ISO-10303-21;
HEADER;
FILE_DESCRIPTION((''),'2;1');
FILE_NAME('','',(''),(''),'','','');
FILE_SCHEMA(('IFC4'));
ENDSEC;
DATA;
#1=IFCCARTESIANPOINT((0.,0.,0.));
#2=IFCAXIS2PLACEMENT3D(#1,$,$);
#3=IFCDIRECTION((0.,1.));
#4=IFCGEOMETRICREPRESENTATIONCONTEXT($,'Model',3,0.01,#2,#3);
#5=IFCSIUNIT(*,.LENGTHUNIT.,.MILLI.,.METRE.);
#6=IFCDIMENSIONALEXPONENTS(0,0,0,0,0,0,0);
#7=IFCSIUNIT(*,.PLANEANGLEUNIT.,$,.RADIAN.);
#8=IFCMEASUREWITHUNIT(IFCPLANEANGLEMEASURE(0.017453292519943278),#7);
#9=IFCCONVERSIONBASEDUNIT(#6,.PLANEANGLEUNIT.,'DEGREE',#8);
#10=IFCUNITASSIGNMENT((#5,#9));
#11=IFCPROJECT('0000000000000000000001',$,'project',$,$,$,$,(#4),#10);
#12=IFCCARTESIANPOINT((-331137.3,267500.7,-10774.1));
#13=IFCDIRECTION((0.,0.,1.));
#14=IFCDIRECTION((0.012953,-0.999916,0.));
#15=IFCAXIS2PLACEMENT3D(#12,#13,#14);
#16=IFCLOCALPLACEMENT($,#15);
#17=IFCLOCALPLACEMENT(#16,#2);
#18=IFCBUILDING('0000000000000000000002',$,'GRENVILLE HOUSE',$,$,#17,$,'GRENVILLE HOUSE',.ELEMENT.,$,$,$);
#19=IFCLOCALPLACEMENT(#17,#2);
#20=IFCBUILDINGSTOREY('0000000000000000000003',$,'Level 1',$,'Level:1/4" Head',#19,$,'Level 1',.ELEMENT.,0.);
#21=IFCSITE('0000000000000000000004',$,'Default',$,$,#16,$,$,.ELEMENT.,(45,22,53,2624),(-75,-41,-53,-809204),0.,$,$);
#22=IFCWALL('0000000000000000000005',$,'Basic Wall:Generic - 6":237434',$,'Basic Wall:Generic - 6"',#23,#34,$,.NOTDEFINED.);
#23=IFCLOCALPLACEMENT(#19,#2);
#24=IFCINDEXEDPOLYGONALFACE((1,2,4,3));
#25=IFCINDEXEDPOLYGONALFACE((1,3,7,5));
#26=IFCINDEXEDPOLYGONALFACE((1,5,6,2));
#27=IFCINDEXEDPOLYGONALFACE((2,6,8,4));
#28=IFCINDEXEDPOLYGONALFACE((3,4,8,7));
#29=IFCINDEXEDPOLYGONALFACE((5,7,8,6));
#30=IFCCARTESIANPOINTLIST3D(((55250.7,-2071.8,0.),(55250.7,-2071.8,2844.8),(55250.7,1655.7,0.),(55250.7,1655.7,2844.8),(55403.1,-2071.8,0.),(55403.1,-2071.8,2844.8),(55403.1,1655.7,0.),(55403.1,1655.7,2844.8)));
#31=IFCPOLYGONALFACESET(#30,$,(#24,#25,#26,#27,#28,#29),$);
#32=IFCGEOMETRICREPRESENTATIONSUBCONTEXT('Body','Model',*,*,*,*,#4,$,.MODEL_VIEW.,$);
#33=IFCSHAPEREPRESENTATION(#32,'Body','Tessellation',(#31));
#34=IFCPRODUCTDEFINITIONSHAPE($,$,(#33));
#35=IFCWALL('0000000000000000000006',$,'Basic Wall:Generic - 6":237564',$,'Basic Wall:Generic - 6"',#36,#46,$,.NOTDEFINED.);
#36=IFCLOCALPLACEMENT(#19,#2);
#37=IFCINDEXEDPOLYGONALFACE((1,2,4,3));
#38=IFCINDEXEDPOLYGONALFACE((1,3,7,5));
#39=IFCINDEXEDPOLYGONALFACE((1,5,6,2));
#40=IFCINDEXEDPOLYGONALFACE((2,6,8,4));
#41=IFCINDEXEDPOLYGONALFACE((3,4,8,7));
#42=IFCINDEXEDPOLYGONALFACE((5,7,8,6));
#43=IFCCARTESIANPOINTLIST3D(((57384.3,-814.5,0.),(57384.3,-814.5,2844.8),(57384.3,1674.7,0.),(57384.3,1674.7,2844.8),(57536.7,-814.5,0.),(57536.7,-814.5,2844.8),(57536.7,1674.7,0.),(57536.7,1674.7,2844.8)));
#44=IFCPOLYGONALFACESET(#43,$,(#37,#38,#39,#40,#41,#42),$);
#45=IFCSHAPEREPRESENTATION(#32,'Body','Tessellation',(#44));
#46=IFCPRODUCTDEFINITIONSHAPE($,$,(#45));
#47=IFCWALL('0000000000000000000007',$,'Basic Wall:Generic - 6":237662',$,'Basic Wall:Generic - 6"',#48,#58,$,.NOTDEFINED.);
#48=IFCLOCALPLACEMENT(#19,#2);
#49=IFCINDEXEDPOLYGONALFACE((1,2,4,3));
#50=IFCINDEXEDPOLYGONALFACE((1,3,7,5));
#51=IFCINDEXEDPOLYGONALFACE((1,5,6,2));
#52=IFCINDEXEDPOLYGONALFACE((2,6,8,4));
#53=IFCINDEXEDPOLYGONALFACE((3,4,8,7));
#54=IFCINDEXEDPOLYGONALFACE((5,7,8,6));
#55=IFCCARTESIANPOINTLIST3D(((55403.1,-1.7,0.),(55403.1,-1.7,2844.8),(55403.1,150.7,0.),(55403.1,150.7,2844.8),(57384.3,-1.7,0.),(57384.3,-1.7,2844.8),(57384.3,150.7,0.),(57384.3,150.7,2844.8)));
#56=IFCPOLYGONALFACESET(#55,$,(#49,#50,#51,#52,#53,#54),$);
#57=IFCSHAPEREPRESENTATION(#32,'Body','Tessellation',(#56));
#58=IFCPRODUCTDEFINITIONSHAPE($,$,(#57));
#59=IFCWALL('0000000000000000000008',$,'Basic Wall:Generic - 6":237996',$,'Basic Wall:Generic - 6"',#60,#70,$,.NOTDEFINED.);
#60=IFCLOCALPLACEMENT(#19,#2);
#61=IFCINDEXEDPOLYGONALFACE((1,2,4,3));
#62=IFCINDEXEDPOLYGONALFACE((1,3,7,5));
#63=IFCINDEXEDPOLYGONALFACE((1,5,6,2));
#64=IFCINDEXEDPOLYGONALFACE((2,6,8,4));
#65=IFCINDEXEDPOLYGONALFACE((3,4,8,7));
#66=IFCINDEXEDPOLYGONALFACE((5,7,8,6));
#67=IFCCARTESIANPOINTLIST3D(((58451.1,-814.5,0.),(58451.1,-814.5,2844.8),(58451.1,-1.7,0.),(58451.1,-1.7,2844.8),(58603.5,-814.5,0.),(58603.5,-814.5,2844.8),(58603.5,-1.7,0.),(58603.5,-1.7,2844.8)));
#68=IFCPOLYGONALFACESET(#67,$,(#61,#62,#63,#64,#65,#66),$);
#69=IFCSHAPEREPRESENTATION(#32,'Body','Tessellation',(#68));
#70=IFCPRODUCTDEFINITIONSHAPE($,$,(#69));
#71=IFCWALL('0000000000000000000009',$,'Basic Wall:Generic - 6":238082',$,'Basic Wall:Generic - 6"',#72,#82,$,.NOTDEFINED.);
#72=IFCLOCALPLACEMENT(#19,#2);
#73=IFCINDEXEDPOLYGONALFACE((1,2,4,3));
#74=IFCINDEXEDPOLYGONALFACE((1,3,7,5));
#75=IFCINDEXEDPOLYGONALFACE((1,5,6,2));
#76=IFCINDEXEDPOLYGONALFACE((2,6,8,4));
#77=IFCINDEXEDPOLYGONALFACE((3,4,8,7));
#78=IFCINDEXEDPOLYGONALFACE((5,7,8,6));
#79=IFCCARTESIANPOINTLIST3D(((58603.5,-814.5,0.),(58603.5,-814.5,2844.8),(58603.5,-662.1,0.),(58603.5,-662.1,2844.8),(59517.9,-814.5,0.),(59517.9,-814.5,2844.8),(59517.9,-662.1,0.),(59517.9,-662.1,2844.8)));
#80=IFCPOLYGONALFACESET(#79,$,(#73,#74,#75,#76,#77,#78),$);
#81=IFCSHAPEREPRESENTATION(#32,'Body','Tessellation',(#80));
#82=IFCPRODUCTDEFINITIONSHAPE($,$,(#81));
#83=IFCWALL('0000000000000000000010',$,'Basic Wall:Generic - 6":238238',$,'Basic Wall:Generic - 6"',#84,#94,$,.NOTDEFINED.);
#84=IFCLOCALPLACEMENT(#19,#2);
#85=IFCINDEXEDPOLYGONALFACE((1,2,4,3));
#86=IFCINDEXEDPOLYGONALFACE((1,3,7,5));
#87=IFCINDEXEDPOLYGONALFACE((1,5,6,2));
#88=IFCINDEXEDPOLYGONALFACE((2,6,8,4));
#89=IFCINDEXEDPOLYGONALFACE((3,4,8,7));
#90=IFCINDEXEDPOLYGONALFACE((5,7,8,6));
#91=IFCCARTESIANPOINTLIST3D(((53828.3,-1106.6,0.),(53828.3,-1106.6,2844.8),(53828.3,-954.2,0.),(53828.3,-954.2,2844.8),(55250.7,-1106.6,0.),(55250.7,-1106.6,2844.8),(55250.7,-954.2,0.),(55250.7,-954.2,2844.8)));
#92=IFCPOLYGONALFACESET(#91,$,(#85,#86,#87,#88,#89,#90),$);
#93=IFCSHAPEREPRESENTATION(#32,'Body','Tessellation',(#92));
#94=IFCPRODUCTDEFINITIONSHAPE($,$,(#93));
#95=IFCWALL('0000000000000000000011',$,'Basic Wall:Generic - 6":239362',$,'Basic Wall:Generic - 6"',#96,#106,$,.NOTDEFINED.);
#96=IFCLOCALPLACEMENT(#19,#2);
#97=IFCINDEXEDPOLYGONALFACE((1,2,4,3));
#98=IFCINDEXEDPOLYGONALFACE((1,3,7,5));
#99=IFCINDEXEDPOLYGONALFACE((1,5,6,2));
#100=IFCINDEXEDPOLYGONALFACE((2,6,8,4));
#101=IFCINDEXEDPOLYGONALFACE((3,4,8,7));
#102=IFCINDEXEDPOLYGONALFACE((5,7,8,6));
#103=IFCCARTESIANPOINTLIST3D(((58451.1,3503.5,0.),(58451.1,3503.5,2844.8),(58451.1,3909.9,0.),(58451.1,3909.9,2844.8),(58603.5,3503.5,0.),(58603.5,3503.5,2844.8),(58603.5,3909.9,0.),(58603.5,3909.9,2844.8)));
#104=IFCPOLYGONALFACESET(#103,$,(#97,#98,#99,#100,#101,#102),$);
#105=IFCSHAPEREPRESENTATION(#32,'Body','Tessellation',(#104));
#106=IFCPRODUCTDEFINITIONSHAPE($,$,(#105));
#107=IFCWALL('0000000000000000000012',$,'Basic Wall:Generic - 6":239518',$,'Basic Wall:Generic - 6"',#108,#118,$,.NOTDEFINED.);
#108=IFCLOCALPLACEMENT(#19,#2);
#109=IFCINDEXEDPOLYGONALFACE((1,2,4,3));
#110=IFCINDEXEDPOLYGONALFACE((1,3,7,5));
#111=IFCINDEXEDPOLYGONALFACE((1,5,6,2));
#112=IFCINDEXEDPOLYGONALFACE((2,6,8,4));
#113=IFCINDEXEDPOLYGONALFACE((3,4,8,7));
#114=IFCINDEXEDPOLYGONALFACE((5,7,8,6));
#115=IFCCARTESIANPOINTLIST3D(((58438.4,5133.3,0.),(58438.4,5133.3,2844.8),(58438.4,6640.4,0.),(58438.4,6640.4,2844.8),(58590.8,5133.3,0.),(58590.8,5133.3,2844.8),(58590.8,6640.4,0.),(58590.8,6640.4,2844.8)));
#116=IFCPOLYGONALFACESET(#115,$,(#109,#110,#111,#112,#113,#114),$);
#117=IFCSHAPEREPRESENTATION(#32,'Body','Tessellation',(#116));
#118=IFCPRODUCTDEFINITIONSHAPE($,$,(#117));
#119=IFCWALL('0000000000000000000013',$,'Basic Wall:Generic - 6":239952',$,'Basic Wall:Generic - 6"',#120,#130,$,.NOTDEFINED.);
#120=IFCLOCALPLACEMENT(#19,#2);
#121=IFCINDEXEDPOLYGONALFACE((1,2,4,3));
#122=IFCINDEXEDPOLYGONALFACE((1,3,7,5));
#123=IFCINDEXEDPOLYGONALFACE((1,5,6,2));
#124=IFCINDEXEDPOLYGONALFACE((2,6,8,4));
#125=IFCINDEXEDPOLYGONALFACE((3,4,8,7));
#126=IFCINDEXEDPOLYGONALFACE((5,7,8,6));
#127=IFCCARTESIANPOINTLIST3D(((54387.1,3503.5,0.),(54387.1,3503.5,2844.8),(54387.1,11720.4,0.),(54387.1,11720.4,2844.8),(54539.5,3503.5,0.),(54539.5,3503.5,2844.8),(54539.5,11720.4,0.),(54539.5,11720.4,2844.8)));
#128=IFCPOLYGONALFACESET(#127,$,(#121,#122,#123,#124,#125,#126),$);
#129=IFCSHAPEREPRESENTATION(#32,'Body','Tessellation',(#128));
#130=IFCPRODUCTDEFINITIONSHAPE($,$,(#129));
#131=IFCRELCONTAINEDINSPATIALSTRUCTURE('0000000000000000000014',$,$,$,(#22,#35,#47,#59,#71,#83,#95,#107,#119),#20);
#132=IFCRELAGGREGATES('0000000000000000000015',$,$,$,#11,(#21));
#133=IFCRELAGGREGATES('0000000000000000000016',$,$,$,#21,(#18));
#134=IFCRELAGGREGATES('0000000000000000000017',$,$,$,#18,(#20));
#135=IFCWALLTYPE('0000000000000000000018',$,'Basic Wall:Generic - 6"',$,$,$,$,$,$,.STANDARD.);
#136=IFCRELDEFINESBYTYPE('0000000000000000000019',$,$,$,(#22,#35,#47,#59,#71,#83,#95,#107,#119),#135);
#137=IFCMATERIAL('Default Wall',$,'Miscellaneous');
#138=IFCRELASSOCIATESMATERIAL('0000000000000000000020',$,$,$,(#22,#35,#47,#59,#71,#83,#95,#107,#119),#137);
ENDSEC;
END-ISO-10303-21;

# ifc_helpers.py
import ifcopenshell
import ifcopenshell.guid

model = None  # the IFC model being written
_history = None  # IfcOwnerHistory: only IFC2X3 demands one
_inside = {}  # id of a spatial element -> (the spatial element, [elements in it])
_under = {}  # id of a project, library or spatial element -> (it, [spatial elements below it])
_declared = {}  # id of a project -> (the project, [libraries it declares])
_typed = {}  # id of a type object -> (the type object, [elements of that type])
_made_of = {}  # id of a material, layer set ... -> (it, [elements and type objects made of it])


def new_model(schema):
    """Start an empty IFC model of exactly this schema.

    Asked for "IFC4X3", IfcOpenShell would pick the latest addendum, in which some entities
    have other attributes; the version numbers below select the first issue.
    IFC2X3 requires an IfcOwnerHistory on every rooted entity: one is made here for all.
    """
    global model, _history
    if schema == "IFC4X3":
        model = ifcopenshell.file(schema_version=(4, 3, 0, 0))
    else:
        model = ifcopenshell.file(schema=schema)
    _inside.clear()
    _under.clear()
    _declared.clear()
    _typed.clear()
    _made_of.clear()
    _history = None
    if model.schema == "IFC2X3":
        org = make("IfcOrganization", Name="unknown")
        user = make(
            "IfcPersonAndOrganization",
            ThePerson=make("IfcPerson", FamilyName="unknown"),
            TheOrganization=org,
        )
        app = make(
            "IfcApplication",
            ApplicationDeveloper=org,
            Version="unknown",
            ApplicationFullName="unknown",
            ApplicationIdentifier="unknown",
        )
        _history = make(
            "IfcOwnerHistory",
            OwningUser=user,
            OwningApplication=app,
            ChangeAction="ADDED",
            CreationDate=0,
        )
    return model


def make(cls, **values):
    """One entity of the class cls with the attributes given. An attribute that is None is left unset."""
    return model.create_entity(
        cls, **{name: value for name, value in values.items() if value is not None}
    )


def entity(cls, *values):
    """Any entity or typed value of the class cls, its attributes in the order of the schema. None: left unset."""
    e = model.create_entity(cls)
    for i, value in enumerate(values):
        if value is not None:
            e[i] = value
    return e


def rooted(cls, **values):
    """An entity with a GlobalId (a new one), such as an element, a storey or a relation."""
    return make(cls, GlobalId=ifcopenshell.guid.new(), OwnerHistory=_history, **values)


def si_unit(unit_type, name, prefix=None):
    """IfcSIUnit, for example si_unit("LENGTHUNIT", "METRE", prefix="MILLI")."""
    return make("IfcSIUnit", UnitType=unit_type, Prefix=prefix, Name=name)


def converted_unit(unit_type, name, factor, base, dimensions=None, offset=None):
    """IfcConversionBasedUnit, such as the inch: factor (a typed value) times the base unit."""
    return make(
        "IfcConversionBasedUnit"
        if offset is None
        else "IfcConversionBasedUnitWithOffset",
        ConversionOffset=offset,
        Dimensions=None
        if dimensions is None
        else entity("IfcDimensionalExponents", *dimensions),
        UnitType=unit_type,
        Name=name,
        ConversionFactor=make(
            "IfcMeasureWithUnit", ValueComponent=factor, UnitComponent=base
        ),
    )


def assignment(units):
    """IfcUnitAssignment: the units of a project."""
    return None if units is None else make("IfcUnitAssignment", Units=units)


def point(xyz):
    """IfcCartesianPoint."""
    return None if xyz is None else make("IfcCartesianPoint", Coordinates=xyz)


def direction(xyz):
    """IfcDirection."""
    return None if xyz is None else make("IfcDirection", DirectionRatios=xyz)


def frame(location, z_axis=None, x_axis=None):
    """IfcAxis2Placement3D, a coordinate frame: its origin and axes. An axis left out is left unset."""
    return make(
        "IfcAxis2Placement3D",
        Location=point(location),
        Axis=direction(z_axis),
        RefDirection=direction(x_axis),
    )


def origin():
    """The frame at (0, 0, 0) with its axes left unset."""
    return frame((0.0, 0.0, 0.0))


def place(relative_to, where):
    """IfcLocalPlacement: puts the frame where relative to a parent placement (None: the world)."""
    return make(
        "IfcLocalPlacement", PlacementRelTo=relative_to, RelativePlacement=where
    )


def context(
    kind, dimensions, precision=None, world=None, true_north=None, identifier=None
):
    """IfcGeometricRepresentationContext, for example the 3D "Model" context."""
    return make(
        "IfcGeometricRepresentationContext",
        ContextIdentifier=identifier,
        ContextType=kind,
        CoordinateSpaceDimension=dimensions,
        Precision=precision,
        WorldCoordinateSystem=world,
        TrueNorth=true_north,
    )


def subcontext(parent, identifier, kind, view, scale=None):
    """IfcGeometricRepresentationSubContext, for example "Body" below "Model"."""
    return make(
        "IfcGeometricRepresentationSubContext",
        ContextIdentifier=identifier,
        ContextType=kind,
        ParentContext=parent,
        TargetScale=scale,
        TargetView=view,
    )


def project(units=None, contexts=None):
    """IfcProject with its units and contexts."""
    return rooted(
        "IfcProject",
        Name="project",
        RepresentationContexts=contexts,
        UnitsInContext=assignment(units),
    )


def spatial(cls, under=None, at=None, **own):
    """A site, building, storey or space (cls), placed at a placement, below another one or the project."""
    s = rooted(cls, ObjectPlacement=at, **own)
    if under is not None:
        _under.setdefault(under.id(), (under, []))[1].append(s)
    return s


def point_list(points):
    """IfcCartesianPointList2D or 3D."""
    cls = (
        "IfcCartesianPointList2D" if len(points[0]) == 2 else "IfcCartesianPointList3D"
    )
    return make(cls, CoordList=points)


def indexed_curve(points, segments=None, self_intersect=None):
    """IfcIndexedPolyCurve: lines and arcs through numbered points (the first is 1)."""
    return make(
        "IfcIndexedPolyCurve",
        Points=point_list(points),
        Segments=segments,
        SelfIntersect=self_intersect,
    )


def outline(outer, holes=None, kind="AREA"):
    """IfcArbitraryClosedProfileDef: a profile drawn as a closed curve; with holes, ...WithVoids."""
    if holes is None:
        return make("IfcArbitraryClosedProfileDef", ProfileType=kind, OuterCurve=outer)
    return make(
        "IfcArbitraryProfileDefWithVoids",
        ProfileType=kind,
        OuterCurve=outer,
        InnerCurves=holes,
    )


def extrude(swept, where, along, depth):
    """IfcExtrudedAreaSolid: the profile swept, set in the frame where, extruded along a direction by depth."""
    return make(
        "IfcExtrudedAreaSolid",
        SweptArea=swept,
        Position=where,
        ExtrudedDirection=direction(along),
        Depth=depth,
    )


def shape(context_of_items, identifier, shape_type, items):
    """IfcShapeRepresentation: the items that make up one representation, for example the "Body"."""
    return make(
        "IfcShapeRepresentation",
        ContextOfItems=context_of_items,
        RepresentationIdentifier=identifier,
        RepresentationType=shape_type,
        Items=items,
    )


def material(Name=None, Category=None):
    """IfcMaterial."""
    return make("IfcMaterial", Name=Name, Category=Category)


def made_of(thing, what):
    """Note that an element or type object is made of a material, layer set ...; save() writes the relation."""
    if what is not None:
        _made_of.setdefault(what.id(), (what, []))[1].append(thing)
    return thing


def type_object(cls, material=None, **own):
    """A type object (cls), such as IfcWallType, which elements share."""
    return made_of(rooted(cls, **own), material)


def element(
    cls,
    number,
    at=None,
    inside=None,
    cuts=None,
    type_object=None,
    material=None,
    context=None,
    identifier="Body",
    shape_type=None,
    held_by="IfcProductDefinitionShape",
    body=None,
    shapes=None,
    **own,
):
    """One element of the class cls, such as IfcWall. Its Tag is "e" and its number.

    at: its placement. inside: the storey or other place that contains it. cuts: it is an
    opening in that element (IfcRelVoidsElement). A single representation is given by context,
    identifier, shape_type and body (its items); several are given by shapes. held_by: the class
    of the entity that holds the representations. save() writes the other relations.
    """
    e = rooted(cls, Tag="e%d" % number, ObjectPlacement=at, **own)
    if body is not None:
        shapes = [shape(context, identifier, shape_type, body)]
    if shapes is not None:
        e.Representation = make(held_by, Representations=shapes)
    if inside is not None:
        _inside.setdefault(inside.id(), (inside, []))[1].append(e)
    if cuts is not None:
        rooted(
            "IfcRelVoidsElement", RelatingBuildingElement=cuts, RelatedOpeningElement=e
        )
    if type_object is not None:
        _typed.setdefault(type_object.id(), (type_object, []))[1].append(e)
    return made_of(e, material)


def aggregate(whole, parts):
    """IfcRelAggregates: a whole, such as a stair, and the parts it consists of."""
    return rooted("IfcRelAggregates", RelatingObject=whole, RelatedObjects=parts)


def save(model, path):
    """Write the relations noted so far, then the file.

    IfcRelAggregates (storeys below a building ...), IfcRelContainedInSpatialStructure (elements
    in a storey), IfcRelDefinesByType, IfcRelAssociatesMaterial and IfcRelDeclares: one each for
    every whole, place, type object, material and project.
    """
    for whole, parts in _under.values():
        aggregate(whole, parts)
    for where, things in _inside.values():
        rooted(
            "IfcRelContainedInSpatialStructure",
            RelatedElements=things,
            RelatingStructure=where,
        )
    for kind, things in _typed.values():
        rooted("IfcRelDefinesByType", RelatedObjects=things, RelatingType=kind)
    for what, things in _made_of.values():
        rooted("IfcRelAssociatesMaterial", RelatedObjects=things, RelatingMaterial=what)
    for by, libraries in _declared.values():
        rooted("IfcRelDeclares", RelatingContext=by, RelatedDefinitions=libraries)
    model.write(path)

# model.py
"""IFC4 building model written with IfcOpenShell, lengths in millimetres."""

from ifc_helpers import new_model, entity, si_unit, converted_unit, direction, frame, origin, place, context, subcontext, project, spatial, indexed_curve, outline, extrude, material, type_object, element, save


model = new_model("IFC4")

# Units and contexts
model_context = context("Model", 3, precision=0.01, world=origin(), true_north=direction((0.0, 1.0)))
body_context = subcontext(model_context, "Body", "Model", "MODEL_VIEW")
ifc_project = project(units=[si_unit("LENGTHUNIT", "METRE", prefix="MILLI"), converted_unit("PLANEANGLEUNIT", "DEGREE", entity("IfcPlaneAngleMeasure", 0.017453292519943278), si_unit("PLANEANGLEUNIT", "RADIAN"), dimensions=[0, 0, 0, 0, 0, 0, 0])], contexts=[model_context])

# Site, building, storey
site_placement = place(None, frame((-331137.3, 267500.7, -10774.1), z_axis=(0.0, 0.0, 1.0), x_axis=(0.012953, -0.999916, 0.0)))
site = spatial("IfcSite", under=ifc_project, at=site_placement, Name="Default", CompositionType="ELEMENT", RefLatitude=(45, 22, 53, 2624), RefLongitude=(-75, -41, -53, -809204), RefElevation=0.0)
building_placement = place(site_placement, origin())
building = spatial("IfcBuilding", under=site, at=building_placement, Name="GRENVILLE HOUSE", LongName="GRENVILLE HOUSE", CompositionType="ELEMENT")
storey_placement = place(building_placement, origin())
storey = spatial("IfcBuildingStorey", under=building, at=storey_placement, Name="Level 1", ObjectType="Level:1/4\" Head", LongName="Level 1", CompositionType="ELEMENT", Elevation=0.0)

# Walls
ifc_material = material(Name="Default Wall", Category="Miscellaneous")
wall_type = type_object("IfcWallType", Name="Basic Wall:Generic - 6\"", PredefinedType="STANDARD")
wall_1_placement = place(storey_placement, frame((55326.9, 1655.7, 0.0), z_axis=(0.0, 0.0, 1.0), x_axis=(0.0, -1.0, 0.0)))
element("IfcWall", 1, at=wall_1_placement, inside=storey, type_object=wall_type, material=ifc_material, Name="Basic Wall:Generic - 6\":237434", ObjectType="Basic Wall:Generic - 6\"", PredefinedType="NOTDEFINED", context=body_context, shape_type="SweptSolid", body=[
    extrude(outline(indexed_curve([(3727.5, 76.2), (0.0, 76.2), (0.0, -76.2), (3727.5, -76.2), (3727.5, 76.2)], self_intersect=False)), origin(), (0.0, 0.0, 1.0), 2844.8),
])
wall_2_placement = place(storey_placement, frame((57460.5, 1674.7, 0.0), z_axis=(0.0, 0.0, 1.0), x_axis=(0.0, -1.0, 0.0)))
element("IfcWall", 2, at=wall_2_placement, inside=storey, type_object=wall_type, material=ifc_material, Name="Basic Wall:Generic - 6\":237564", ObjectType="Basic Wall:Generic - 6\"", PredefinedType="NOTDEFINED", context=body_context, shape_type="SweptSolid", body=[
    extrude(outline(indexed_curve([(2489.2, 76.2), (0.0, 76.2), (0.0, -76.2), (2489.2, -76.2), (2489.2, 76.2)], self_intersect=False)), origin(), (0.0, 0.0, 1.0), 2844.8),
])
wall_3_placement = place(storey_placement, frame((55403.1, 74.5, 0.0)))
element("IfcWall", 3, at=wall_3_placement, inside=storey, type_object=wall_type, material=ifc_material, Name="Basic Wall:Generic - 6\":237662", ObjectType="Basic Wall:Generic - 6\"", PredefinedType="NOTDEFINED", context=body_context, shape_type="SweptSolid", body=[
    extrude(outline(indexed_curve([(1981.2, 76.2), (0.0, 76.2), (0.0, -76.2), (1981.2, -76.2), (1981.2, 76.2)], self_intersect=False)), origin(), (0.0, 0.0, 1.0), 2844.8),
])
wall_4_placement = place(storey_placement, frame((58527.3, -1.7, 0.0), z_axis=(0.0, 0.0, 1.0), x_axis=(0.0, -1.0, 0.0)))
element("IfcWall", 4, at=wall_4_placement, inside=storey, type_object=wall_type, material=ifc_material, Name="Basic Wall:Generic - 6\":237996", ObjectType="Basic Wall:Generic - 6\"", PredefinedType="NOTDEFINED", context=body_context, shape_type="SweptSolid", body=[
    extrude(outline(indexed_curve([(812.8, 76.2), (0.0, 76.2), (0.0, -76.2), (812.8, -76.2), (812.8, 76.2)], self_intersect=False)), origin(), (0.0, 0.0, 1.0), 2844.8),
])
wall_5_placement = place(storey_placement, frame((58603.5, -738.3, 0.0)))
element("IfcWall", 5, at=wall_5_placement, inside=storey, type_object=wall_type, material=ifc_material, Name="Basic Wall:Generic - 6\":238082", ObjectType="Basic Wall:Generic - 6\"", PredefinedType="NOTDEFINED", context=body_context, shape_type="SweptSolid", body=[
    extrude(outline(indexed_curve([(914.4, 76.2), (0.0, 76.2), (0.0, -76.2), (914.4, -76.2), (914.4, 76.2)], self_intersect=False)), origin(), (0.0, 0.0, 1.0), 2844.8),
])
wall_6_placement = place(storey_placement, frame((55250.7, -1030.4, 0.0), z_axis=(0.0, 0.0, 1.0), x_axis=(-1.0, 0.0, 0.0)))
element("IfcWall", 6, at=wall_6_placement, inside=storey, type_object=wall_type, material=ifc_material, Name="Basic Wall:Generic - 6\":238238", ObjectType="Basic Wall:Generic - 6\"", PredefinedType="NOTDEFINED", context=body_context, shape_type="SweptSolid", body=[
    extrude(outline(indexed_curve([(1422.4, 76.2), (0.0, 76.2), (0.0, -76.2), (1422.4, -76.2), (1422.4, 76.2)], self_intersect=False)), origin(), (0.0, 0.0, 1.0), 2844.8),
])
wall_7_placement = place(storey_placement, frame((58527.3, 3503.5, 0.0), z_axis=(0.0, 0.0, 1.0), x_axis=(0.0, 1.0, 0.0)))
element("IfcWall", 7, at=wall_7_placement, inside=storey, type_object=wall_type, material=ifc_material, Name="Basic Wall:Generic - 6\":239362", ObjectType="Basic Wall:Generic - 6\"", PredefinedType="NOTDEFINED", context=body_context, shape_type="SweptSolid", body=[
    extrude(outline(indexed_curve([(406.4, 76.2), (0.0, 76.2), (0.0, -76.2), (406.4, -76.2), (406.4, 76.2)], self_intersect=False)), origin(), (0.0, 0.0, 1.0), 2844.8),
])
wall_8_placement = place(storey_placement, frame((58514.6, 5133.3, 0.0), z_axis=(0.0, 0.0, 1.0), x_axis=(0.0, 1.0, 0.0)))
element("IfcWall", 8, at=wall_8_placement, inside=storey, type_object=wall_type, material=ifc_material, Name="Basic Wall:Generic - 6\":239518", ObjectType="Basic Wall:Generic - 6\"", PredefinedType="NOTDEFINED", context=body_context, shape_type="SweptSolid", body=[
    extrude(outline(indexed_curve([(1507.1, 76.2), (0.0, 76.2), (0.0, -76.2), (1507.1, -76.2), (1507.1, 76.2)], self_intersect=False)), origin(), (0.0, 0.0, 1.0), 2844.8),
])
wall_9_placement = place(storey_placement, frame((54463.3, 3503.5, 0.0), z_axis=(0.0, 0.0, 1.0), x_axis=(0.0, 1.0, 0.0)))
element("IfcWall", 9, at=wall_9_placement, inside=storey, type_object=wall_type, material=ifc_material, Name="Basic Wall:Generic - 6\":239952", ObjectType="Basic Wall:Generic - 6\"", PredefinedType="NOTDEFINED", context=body_context, shape_type="SweptSolid", body=[
    extrude(outline(indexed_curve([(8216.9, 76.2), (0.0, 76.2), (0.0, -76.2), (8216.9, -76.2), (8216.9, 76.2)], self_intersect=False)), origin(), (0.0, 0.0, 1.0), 2844.8),
])

save(model, "model.ifc")
